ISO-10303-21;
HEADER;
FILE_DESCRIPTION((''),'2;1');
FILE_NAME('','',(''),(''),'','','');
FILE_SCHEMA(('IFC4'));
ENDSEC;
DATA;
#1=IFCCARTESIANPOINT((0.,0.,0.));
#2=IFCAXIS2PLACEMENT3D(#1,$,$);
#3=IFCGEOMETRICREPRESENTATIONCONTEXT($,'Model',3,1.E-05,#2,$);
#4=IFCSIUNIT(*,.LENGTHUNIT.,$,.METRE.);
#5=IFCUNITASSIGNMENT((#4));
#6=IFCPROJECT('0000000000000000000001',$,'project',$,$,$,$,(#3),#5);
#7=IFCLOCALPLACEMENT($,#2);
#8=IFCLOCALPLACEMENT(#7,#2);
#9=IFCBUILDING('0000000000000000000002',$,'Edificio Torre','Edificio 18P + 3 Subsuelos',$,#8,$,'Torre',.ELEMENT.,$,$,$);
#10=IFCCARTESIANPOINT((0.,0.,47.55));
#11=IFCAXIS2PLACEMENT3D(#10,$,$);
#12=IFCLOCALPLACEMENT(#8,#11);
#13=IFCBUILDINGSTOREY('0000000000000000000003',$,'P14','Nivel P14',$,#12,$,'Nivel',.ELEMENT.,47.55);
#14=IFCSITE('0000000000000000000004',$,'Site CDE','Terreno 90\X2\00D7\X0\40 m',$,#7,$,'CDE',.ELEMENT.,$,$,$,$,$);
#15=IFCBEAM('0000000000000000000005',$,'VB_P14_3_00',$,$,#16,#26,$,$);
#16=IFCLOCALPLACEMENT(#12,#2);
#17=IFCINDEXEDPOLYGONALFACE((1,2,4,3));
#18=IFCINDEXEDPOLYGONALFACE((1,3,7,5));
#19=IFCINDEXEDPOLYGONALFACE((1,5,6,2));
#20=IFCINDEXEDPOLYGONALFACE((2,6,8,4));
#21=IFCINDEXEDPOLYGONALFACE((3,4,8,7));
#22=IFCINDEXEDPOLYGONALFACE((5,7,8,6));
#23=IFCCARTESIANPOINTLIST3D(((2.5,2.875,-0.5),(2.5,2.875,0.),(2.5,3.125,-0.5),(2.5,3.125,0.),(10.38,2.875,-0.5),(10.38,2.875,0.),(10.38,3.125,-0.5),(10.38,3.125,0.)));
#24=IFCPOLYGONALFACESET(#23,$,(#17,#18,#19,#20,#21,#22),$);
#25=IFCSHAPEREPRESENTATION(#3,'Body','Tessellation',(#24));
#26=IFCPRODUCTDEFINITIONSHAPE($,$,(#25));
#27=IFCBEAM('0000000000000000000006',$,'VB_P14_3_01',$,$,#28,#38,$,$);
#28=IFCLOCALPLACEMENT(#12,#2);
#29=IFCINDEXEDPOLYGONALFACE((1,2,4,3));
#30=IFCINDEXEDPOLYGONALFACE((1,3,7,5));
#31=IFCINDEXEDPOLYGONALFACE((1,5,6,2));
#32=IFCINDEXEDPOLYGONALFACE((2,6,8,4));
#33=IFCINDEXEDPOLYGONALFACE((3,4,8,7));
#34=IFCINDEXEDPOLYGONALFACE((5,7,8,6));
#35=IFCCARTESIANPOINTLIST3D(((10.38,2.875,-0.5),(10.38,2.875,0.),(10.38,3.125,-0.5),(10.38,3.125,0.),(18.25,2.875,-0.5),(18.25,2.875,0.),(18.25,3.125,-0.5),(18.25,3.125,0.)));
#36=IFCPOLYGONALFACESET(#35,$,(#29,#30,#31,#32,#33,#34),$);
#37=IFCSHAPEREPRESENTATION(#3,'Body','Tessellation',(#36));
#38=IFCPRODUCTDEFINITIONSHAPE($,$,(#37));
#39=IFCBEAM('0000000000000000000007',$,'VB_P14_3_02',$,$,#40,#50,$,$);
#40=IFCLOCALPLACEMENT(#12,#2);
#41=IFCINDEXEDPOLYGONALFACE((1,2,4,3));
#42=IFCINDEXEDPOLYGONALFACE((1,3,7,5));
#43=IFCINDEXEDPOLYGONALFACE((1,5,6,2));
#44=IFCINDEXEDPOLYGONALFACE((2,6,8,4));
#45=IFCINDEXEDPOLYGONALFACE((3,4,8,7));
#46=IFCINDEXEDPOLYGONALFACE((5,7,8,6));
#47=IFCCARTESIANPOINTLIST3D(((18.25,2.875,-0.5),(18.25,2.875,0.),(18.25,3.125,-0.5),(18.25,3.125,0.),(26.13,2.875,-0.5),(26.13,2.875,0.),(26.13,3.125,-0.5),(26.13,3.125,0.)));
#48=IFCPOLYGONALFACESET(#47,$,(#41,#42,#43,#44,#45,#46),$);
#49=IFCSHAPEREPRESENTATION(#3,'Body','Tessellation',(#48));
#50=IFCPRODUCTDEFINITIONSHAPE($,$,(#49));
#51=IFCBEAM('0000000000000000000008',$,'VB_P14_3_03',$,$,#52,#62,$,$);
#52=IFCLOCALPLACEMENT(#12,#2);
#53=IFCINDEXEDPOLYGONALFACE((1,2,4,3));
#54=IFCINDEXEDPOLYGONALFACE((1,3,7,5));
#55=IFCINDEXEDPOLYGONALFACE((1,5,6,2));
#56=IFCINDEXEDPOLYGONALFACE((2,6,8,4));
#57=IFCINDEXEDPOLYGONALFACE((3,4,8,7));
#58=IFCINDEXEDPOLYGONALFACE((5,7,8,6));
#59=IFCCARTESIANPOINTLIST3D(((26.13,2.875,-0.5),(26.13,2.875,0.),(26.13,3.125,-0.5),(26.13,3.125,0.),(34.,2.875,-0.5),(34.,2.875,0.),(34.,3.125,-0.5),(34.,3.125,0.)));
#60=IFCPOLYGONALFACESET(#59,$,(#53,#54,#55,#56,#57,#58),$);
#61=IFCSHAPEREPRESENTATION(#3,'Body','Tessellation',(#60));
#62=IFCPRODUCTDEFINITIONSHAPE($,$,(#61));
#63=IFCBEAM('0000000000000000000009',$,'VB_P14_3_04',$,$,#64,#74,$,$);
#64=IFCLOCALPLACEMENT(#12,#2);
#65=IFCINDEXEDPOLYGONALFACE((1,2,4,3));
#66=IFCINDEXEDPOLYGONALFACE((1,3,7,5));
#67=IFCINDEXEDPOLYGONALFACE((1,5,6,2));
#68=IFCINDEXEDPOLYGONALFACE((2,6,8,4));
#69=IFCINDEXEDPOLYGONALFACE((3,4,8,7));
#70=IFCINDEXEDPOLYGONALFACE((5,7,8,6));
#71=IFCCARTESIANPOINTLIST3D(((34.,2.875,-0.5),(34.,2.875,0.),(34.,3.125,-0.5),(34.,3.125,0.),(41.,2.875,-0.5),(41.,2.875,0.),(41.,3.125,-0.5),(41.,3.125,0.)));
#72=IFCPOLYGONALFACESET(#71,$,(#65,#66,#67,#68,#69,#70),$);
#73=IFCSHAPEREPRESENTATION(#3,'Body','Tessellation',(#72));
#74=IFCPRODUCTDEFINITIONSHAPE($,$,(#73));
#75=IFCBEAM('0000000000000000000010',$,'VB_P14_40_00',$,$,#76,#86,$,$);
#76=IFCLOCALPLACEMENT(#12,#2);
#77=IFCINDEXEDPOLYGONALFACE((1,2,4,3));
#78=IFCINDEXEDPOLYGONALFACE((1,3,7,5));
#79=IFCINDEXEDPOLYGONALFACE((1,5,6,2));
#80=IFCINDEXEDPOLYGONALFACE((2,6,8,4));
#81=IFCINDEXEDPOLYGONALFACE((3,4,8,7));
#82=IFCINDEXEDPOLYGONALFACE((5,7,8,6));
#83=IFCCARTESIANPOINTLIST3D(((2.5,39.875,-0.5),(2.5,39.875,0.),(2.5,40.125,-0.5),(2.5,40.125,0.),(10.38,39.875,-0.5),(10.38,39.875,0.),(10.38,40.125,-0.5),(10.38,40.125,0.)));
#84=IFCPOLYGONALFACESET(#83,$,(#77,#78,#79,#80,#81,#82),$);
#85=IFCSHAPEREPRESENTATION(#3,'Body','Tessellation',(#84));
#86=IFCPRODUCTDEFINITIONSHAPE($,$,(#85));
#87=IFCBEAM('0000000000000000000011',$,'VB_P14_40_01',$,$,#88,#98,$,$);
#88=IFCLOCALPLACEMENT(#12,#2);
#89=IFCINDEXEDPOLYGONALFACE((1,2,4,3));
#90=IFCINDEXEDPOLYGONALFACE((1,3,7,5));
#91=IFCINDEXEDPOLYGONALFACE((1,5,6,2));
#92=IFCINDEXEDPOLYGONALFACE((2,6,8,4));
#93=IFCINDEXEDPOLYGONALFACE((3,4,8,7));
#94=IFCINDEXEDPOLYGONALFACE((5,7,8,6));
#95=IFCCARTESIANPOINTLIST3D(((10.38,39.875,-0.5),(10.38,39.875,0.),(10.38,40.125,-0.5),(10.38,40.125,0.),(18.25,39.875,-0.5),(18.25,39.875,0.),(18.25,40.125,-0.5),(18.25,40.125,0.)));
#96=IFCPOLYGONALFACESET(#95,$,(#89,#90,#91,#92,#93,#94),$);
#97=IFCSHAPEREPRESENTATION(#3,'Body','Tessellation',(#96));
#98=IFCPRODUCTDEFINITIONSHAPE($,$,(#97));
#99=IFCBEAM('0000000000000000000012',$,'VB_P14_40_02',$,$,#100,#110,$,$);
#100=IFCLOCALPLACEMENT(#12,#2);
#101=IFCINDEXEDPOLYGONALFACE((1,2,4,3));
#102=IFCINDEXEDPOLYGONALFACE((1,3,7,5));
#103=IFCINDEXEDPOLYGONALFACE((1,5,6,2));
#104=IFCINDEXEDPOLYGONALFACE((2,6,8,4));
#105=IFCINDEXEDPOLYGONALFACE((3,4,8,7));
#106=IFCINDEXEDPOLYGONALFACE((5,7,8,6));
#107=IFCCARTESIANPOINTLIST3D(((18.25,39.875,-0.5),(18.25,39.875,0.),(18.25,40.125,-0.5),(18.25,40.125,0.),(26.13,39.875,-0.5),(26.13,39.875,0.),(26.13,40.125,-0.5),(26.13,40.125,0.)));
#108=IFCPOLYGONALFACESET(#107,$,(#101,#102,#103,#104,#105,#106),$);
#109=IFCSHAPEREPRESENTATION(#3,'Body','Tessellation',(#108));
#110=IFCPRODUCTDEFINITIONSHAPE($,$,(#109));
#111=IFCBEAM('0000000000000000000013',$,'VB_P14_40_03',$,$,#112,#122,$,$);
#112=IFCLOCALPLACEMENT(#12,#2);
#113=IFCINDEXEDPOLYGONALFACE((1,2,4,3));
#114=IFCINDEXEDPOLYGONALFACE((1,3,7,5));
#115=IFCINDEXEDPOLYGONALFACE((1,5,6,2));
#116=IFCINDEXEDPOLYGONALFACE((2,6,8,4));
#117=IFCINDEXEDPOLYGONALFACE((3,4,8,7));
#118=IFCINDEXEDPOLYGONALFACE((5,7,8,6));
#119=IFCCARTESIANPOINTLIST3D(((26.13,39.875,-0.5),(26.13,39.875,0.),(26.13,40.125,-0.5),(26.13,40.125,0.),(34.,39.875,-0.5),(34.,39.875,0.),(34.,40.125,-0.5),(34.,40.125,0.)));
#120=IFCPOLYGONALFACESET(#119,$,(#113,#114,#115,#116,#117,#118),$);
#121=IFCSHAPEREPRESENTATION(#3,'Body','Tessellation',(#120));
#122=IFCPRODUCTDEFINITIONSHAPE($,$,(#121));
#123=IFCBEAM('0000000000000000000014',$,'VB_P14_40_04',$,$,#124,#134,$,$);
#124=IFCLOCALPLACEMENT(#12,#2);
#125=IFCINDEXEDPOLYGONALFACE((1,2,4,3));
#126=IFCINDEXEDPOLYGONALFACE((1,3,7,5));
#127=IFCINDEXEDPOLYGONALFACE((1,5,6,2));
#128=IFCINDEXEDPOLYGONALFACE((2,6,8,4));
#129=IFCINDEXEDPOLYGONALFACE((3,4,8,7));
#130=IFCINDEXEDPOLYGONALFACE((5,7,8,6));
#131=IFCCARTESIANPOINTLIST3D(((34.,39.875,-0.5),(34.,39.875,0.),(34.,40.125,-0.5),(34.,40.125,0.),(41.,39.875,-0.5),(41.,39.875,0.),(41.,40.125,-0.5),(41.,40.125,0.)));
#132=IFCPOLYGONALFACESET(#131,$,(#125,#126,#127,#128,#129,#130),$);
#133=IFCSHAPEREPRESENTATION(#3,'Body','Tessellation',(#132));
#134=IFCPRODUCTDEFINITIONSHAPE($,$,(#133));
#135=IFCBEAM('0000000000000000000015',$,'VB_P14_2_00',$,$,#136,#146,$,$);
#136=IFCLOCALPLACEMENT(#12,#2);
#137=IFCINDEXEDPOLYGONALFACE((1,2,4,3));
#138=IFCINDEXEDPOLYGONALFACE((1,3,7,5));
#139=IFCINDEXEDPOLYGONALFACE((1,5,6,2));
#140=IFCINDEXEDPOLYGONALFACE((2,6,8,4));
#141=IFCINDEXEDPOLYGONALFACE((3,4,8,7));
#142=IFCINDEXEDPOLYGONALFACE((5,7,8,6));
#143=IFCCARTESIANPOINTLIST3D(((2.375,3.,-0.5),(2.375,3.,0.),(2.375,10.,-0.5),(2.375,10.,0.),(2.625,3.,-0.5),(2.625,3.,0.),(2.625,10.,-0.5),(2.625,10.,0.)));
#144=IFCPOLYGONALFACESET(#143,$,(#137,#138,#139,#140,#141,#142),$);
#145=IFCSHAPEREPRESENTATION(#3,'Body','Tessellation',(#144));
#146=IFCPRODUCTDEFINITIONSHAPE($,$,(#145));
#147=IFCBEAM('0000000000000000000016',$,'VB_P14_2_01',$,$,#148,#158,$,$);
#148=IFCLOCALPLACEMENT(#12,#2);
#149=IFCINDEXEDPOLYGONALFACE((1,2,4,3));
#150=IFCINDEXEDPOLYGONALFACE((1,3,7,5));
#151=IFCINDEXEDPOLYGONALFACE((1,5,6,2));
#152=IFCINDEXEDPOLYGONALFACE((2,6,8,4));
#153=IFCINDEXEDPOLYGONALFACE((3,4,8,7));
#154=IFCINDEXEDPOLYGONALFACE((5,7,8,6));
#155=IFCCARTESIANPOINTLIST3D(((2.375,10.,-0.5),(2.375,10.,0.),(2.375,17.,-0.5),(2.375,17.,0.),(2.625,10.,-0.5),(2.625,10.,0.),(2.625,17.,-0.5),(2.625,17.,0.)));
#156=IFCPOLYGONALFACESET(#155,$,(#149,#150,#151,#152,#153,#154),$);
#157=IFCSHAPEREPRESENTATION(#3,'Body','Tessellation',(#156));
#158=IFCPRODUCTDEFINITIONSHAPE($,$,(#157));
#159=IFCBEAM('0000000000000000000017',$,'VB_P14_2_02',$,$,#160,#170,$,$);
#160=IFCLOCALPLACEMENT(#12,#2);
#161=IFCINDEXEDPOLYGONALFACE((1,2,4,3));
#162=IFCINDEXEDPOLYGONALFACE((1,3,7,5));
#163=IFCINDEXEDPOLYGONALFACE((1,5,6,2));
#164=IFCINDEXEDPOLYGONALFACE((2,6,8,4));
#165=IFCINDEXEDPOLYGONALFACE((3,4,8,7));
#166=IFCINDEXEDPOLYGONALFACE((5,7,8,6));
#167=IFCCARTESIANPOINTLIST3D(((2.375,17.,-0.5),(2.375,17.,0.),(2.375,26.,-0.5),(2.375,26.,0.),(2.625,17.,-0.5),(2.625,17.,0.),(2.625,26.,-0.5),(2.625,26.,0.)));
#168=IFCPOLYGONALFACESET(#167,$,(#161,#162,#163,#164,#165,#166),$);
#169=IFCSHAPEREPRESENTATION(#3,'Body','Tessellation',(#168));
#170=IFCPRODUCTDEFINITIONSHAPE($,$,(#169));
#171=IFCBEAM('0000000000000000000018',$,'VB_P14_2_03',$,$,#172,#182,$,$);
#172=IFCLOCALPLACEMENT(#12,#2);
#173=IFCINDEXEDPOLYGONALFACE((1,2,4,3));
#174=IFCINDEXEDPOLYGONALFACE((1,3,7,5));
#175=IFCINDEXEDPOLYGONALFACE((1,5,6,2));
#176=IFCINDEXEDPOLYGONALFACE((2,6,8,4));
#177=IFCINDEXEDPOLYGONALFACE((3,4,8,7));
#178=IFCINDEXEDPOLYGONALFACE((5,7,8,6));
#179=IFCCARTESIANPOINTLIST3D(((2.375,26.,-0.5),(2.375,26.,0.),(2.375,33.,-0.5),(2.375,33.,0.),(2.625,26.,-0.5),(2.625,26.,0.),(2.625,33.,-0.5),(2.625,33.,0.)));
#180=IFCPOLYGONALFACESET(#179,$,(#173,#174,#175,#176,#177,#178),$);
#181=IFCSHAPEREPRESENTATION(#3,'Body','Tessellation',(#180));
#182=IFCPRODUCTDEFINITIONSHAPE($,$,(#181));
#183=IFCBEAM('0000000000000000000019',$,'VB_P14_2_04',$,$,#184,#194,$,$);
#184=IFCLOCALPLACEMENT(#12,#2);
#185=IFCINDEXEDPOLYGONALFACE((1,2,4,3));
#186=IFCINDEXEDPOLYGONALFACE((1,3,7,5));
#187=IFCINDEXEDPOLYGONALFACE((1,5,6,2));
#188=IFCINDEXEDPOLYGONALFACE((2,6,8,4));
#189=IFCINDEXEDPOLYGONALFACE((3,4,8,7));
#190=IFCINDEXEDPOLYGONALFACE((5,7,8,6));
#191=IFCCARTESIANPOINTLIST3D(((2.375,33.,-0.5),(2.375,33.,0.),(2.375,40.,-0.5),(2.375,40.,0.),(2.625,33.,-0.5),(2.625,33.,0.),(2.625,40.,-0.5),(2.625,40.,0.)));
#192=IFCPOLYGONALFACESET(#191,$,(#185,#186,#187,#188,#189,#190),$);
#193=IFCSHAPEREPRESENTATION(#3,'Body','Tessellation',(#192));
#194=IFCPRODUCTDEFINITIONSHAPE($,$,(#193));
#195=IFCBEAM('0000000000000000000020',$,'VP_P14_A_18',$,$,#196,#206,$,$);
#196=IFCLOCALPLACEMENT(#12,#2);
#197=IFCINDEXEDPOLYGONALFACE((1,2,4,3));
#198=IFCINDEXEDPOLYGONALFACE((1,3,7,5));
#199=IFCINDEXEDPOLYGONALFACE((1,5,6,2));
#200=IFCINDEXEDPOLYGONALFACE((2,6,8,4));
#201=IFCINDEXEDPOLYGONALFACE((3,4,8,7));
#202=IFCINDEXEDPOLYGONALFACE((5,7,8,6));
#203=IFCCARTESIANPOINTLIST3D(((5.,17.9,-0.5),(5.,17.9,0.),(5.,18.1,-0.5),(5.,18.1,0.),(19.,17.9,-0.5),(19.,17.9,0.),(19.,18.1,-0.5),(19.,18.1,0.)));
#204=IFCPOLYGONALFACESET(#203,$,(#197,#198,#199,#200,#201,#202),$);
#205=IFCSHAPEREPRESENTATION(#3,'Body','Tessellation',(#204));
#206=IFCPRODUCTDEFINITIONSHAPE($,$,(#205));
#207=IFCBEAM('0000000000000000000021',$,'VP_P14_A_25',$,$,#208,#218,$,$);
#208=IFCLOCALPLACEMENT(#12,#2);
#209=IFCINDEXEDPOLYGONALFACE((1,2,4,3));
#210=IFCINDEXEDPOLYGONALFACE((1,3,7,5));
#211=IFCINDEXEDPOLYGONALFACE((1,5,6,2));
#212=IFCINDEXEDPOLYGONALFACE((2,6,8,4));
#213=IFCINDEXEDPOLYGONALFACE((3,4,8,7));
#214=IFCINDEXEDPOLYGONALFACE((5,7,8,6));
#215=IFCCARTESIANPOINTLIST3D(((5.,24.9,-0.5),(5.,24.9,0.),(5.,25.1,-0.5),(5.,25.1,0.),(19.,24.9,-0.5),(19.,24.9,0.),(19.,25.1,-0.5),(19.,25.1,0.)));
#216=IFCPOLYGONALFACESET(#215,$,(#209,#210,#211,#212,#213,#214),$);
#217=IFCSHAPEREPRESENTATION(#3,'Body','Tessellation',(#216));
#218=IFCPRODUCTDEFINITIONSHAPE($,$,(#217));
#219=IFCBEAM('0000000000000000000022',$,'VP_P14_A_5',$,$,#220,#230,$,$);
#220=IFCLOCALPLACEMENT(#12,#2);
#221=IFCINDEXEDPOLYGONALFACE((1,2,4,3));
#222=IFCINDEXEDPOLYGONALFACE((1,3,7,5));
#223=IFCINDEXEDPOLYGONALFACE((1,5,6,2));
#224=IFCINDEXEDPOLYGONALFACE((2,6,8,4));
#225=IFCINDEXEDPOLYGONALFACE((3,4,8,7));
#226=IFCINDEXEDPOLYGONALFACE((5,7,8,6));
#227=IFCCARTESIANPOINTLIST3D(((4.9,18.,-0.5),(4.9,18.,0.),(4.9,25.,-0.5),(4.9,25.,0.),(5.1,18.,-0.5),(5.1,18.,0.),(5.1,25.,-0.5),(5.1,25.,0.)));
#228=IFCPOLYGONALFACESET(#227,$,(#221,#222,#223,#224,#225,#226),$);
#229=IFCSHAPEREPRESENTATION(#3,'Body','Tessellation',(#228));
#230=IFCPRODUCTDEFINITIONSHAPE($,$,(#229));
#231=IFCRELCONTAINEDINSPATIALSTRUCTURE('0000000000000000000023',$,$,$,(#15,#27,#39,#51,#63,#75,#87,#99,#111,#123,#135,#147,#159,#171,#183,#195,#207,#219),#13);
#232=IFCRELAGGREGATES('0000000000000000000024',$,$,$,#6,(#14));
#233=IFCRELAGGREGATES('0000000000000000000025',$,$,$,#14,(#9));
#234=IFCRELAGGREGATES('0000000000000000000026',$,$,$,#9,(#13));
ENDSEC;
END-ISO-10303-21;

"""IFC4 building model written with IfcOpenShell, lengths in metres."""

from ifc_helpers import new_model, si_unit, frame, origin, origin_2d, place, context, project, spatial, rectangle, extrude, element, save


model = new_model("IFC4")

# Units and contexts
model_context = context("Model", 3, precision=1e-05, world=origin())
ifc_project = project(units=[si_unit("LENGTHUNIT", "METRE")], contexts=[model_context])

# Site, building, storey
site_placement = place(None, origin())
site = spatial("IfcSite", under=ifc_project, at=site_placement, Name="Site CDE", Description="Terreno 90×40 m", LongName="CDE", CompositionType="ELEMENT")
building_placement = place(site_placement, origin())
building = spatial("IfcBuilding", under=site, at=building_placement, Name="Edificio Torre", Description="Edificio 18P + 3 Subsuelos", LongName="Torre", CompositionType="ELEMENT")
storey_placement = place(building_placement, frame((0.0, 0.0, 47.55)))
storey = spatial("IfcBuildingStorey", under=building, at=storey_placement, Name="P14", Description="Nivel P14", LongName="Nivel", CompositionType="ELEMENT", Elevation=47.55)

# Beams
beam_1_placement = place(storey_placement, frame((6.44, 3.0, -0.5)))
element("IfcBeam", 1, at=beam_1_placement, inside=storey, Name="VB_P14_3_00", context=model_context, shape_type="SweptSolid", body=[
    extrude(rectangle(XDim=7.88, YDim=0.25, at=origin_2d()), origin(), (0.0, 0.0, 1.0), 0.5),
])
beam_2_placement = place(storey_placement, frame((14.315, 3.0, -0.5)))
element("IfcBeam", 2, at=beam_2_placement, inside=storey, Name="VB_P14_3_01", context=model_context, shape_type="SweptSolid", body=[
    extrude(rectangle(XDim=7.87, YDim=0.25, at=origin_2d()), origin(), (0.0, 0.0, 1.0), 0.5),
])
beam_3_placement = place(storey_placement, frame((22.19, 3.0, -0.5)))
element("IfcBeam", 3, at=beam_3_placement, inside=storey, Name="VB_P14_3_02", context=model_context, shape_type="SweptSolid", body=[
    extrude(rectangle(XDim=7.88, YDim=0.25, at=origin_2d()), origin(), (0.0, 0.0, 1.0), 0.5),
])
beam_4_placement = place(storey_placement, frame((30.065, 3.0, -0.5)))
element("IfcBeam", 4, at=beam_4_placement, inside=storey, Name="VB_P14_3_03", context=model_context, shape_type="SweptSolid", body=[
    extrude(rectangle(XDim=7.87, YDim=0.25, at=origin_2d()), origin(), (0.0, 0.0, 1.0), 0.5),
])
beam_5_placement = place(storey_placement, frame((37.5, 3.0, -0.5)))
element("IfcBeam", 5, at=beam_5_placement, inside=storey, Name="VB_P14_3_04", context=model_context, shape_type="SweptSolid", body=[
    extrude(rectangle(XDim=7.0, YDim=0.25, at=origin_2d()), origin(), (0.0, 0.0, 1.0), 0.5),
])
beam_6_placement = place(storey_placement, frame((6.44, 40.0, -0.5)))
element("IfcBeam", 6, at=beam_6_placement, inside=storey, Name="VB_P14_40_00", context=model_context, shape_type="SweptSolid", body=[
    extrude(rectangle(XDim=7.88, YDim=0.25, at=origin_2d()), origin(), (0.0, 0.0, 1.0), 0.5),
])
beam_7_placement = place(storey_placement, frame((14.315, 40.0, -0.5)))
element("IfcBeam", 7, at=beam_7_placement, inside=storey, Name="VB_P14_40_01", context=model_context, shape_type="SweptSolid", body=[
    extrude(rectangle(XDim=7.87, YDim=0.25, at=origin_2d()), origin(), (0.0, 0.0, 1.0), 0.5),
])
beam_8_placement = place(storey_placement, frame((22.19, 40.0, -0.5)))
element("IfcBeam", 8, at=beam_8_placement, inside=storey, Name="VB_P14_40_02", context=model_context, shape_type="SweptSolid", body=[
    extrude(rectangle(XDim=7.88, YDim=0.25, at=origin_2d()), origin(), (0.0, 0.0, 1.0), 0.5),
])
beam_9_placement = place(storey_placement, frame((30.065, 40.0, -0.5)))
element("IfcBeam", 9, at=beam_9_placement, inside=storey, Name="VB_P14_40_03", context=model_context, shape_type="SweptSolid", body=[
    extrude(rectangle(XDim=7.87, YDim=0.25, at=origin_2d()), origin(), (0.0, 0.0, 1.0), 0.5),
])
beam_10_placement = place(storey_placement, frame((37.5, 40.0, -0.5)))
element("IfcBeam", 10, at=beam_10_placement, inside=storey, Name="VB_P14_40_04", context=model_context, shape_type="SweptSolid", body=[
    extrude(rectangle(XDim=7.0, YDim=0.25, at=origin_2d()), origin(), (0.0, 0.0, 1.0), 0.5),
])
for number, where, name in (
    (11, (2.5, 6.5, -0.5), "VB_P14_2_00"),
    (12, (2.5, 13.5, -0.5), "VB_P14_2_01"),
):
    element("IfcBeam", number, at=place(storey_placement, frame(where)), inside=storey, Name=name, context=model_context, shape_type="SweptSolid", body=[
        extrude(rectangle(XDim=0.25, YDim=7.0, at=origin_2d()), origin(), (0.0, 0.0, 1.0), 0.5),
    ])
beam_11_placement = place(storey_placement, frame((2.5, 21.5, -0.5)))
element("IfcBeam", 13, at=beam_11_placement, inside=storey, Name="VB_P14_2_02", context=model_context, shape_type="SweptSolid", body=[
    extrude(rectangle(XDim=0.25, YDim=9.0, at=origin_2d()), origin(), (0.0, 0.0, 1.0), 0.5),
])
for number, where, name in (
    (14, (2.5, 29.5, -0.5), "VB_P14_2_03"),
    (15, (2.5, 36.5, -0.5), "VB_P14_2_04"),
):
    element("IfcBeam", number, at=place(storey_placement, frame(where)), inside=storey, Name=name, context=model_context, shape_type="SweptSolid", body=[
        extrude(rectangle(XDim=0.25, YDim=7.0, at=origin_2d()), origin(), (0.0, 0.0, 1.0), 0.5),
    ])
for number, where, name in (
    (16, (12.0, 18.0, -0.5), "VP_P14_A_18"),
    (17, (12.0, 25.0, -0.5), "VP_P14_A_25"),
):
    element("IfcBeam", number, at=place(storey_placement, frame(where)), inside=storey, Name=name, context=model_context, shape_type="SweptSolid", body=[
        extrude(rectangle(XDim=14.0, YDim=0.2, at=origin_2d()), origin(), (0.0, 0.0, 1.0), 0.5),
    ])
beam_12_placement = place(storey_placement, frame((5.0, 21.5, -0.5)))
element("IfcBeam", 18, at=beam_12_placement, inside=storey, Name="VP_P14_A_5", context=model_context, shape_type="SweptSolid", body=[
    extrude(rectangle(XDim=0.2, YDim=7.0, at=origin_2d()), origin(), (0.0, 0.0, 1.0), 0.5),
])

save(model, "model.ifc")
